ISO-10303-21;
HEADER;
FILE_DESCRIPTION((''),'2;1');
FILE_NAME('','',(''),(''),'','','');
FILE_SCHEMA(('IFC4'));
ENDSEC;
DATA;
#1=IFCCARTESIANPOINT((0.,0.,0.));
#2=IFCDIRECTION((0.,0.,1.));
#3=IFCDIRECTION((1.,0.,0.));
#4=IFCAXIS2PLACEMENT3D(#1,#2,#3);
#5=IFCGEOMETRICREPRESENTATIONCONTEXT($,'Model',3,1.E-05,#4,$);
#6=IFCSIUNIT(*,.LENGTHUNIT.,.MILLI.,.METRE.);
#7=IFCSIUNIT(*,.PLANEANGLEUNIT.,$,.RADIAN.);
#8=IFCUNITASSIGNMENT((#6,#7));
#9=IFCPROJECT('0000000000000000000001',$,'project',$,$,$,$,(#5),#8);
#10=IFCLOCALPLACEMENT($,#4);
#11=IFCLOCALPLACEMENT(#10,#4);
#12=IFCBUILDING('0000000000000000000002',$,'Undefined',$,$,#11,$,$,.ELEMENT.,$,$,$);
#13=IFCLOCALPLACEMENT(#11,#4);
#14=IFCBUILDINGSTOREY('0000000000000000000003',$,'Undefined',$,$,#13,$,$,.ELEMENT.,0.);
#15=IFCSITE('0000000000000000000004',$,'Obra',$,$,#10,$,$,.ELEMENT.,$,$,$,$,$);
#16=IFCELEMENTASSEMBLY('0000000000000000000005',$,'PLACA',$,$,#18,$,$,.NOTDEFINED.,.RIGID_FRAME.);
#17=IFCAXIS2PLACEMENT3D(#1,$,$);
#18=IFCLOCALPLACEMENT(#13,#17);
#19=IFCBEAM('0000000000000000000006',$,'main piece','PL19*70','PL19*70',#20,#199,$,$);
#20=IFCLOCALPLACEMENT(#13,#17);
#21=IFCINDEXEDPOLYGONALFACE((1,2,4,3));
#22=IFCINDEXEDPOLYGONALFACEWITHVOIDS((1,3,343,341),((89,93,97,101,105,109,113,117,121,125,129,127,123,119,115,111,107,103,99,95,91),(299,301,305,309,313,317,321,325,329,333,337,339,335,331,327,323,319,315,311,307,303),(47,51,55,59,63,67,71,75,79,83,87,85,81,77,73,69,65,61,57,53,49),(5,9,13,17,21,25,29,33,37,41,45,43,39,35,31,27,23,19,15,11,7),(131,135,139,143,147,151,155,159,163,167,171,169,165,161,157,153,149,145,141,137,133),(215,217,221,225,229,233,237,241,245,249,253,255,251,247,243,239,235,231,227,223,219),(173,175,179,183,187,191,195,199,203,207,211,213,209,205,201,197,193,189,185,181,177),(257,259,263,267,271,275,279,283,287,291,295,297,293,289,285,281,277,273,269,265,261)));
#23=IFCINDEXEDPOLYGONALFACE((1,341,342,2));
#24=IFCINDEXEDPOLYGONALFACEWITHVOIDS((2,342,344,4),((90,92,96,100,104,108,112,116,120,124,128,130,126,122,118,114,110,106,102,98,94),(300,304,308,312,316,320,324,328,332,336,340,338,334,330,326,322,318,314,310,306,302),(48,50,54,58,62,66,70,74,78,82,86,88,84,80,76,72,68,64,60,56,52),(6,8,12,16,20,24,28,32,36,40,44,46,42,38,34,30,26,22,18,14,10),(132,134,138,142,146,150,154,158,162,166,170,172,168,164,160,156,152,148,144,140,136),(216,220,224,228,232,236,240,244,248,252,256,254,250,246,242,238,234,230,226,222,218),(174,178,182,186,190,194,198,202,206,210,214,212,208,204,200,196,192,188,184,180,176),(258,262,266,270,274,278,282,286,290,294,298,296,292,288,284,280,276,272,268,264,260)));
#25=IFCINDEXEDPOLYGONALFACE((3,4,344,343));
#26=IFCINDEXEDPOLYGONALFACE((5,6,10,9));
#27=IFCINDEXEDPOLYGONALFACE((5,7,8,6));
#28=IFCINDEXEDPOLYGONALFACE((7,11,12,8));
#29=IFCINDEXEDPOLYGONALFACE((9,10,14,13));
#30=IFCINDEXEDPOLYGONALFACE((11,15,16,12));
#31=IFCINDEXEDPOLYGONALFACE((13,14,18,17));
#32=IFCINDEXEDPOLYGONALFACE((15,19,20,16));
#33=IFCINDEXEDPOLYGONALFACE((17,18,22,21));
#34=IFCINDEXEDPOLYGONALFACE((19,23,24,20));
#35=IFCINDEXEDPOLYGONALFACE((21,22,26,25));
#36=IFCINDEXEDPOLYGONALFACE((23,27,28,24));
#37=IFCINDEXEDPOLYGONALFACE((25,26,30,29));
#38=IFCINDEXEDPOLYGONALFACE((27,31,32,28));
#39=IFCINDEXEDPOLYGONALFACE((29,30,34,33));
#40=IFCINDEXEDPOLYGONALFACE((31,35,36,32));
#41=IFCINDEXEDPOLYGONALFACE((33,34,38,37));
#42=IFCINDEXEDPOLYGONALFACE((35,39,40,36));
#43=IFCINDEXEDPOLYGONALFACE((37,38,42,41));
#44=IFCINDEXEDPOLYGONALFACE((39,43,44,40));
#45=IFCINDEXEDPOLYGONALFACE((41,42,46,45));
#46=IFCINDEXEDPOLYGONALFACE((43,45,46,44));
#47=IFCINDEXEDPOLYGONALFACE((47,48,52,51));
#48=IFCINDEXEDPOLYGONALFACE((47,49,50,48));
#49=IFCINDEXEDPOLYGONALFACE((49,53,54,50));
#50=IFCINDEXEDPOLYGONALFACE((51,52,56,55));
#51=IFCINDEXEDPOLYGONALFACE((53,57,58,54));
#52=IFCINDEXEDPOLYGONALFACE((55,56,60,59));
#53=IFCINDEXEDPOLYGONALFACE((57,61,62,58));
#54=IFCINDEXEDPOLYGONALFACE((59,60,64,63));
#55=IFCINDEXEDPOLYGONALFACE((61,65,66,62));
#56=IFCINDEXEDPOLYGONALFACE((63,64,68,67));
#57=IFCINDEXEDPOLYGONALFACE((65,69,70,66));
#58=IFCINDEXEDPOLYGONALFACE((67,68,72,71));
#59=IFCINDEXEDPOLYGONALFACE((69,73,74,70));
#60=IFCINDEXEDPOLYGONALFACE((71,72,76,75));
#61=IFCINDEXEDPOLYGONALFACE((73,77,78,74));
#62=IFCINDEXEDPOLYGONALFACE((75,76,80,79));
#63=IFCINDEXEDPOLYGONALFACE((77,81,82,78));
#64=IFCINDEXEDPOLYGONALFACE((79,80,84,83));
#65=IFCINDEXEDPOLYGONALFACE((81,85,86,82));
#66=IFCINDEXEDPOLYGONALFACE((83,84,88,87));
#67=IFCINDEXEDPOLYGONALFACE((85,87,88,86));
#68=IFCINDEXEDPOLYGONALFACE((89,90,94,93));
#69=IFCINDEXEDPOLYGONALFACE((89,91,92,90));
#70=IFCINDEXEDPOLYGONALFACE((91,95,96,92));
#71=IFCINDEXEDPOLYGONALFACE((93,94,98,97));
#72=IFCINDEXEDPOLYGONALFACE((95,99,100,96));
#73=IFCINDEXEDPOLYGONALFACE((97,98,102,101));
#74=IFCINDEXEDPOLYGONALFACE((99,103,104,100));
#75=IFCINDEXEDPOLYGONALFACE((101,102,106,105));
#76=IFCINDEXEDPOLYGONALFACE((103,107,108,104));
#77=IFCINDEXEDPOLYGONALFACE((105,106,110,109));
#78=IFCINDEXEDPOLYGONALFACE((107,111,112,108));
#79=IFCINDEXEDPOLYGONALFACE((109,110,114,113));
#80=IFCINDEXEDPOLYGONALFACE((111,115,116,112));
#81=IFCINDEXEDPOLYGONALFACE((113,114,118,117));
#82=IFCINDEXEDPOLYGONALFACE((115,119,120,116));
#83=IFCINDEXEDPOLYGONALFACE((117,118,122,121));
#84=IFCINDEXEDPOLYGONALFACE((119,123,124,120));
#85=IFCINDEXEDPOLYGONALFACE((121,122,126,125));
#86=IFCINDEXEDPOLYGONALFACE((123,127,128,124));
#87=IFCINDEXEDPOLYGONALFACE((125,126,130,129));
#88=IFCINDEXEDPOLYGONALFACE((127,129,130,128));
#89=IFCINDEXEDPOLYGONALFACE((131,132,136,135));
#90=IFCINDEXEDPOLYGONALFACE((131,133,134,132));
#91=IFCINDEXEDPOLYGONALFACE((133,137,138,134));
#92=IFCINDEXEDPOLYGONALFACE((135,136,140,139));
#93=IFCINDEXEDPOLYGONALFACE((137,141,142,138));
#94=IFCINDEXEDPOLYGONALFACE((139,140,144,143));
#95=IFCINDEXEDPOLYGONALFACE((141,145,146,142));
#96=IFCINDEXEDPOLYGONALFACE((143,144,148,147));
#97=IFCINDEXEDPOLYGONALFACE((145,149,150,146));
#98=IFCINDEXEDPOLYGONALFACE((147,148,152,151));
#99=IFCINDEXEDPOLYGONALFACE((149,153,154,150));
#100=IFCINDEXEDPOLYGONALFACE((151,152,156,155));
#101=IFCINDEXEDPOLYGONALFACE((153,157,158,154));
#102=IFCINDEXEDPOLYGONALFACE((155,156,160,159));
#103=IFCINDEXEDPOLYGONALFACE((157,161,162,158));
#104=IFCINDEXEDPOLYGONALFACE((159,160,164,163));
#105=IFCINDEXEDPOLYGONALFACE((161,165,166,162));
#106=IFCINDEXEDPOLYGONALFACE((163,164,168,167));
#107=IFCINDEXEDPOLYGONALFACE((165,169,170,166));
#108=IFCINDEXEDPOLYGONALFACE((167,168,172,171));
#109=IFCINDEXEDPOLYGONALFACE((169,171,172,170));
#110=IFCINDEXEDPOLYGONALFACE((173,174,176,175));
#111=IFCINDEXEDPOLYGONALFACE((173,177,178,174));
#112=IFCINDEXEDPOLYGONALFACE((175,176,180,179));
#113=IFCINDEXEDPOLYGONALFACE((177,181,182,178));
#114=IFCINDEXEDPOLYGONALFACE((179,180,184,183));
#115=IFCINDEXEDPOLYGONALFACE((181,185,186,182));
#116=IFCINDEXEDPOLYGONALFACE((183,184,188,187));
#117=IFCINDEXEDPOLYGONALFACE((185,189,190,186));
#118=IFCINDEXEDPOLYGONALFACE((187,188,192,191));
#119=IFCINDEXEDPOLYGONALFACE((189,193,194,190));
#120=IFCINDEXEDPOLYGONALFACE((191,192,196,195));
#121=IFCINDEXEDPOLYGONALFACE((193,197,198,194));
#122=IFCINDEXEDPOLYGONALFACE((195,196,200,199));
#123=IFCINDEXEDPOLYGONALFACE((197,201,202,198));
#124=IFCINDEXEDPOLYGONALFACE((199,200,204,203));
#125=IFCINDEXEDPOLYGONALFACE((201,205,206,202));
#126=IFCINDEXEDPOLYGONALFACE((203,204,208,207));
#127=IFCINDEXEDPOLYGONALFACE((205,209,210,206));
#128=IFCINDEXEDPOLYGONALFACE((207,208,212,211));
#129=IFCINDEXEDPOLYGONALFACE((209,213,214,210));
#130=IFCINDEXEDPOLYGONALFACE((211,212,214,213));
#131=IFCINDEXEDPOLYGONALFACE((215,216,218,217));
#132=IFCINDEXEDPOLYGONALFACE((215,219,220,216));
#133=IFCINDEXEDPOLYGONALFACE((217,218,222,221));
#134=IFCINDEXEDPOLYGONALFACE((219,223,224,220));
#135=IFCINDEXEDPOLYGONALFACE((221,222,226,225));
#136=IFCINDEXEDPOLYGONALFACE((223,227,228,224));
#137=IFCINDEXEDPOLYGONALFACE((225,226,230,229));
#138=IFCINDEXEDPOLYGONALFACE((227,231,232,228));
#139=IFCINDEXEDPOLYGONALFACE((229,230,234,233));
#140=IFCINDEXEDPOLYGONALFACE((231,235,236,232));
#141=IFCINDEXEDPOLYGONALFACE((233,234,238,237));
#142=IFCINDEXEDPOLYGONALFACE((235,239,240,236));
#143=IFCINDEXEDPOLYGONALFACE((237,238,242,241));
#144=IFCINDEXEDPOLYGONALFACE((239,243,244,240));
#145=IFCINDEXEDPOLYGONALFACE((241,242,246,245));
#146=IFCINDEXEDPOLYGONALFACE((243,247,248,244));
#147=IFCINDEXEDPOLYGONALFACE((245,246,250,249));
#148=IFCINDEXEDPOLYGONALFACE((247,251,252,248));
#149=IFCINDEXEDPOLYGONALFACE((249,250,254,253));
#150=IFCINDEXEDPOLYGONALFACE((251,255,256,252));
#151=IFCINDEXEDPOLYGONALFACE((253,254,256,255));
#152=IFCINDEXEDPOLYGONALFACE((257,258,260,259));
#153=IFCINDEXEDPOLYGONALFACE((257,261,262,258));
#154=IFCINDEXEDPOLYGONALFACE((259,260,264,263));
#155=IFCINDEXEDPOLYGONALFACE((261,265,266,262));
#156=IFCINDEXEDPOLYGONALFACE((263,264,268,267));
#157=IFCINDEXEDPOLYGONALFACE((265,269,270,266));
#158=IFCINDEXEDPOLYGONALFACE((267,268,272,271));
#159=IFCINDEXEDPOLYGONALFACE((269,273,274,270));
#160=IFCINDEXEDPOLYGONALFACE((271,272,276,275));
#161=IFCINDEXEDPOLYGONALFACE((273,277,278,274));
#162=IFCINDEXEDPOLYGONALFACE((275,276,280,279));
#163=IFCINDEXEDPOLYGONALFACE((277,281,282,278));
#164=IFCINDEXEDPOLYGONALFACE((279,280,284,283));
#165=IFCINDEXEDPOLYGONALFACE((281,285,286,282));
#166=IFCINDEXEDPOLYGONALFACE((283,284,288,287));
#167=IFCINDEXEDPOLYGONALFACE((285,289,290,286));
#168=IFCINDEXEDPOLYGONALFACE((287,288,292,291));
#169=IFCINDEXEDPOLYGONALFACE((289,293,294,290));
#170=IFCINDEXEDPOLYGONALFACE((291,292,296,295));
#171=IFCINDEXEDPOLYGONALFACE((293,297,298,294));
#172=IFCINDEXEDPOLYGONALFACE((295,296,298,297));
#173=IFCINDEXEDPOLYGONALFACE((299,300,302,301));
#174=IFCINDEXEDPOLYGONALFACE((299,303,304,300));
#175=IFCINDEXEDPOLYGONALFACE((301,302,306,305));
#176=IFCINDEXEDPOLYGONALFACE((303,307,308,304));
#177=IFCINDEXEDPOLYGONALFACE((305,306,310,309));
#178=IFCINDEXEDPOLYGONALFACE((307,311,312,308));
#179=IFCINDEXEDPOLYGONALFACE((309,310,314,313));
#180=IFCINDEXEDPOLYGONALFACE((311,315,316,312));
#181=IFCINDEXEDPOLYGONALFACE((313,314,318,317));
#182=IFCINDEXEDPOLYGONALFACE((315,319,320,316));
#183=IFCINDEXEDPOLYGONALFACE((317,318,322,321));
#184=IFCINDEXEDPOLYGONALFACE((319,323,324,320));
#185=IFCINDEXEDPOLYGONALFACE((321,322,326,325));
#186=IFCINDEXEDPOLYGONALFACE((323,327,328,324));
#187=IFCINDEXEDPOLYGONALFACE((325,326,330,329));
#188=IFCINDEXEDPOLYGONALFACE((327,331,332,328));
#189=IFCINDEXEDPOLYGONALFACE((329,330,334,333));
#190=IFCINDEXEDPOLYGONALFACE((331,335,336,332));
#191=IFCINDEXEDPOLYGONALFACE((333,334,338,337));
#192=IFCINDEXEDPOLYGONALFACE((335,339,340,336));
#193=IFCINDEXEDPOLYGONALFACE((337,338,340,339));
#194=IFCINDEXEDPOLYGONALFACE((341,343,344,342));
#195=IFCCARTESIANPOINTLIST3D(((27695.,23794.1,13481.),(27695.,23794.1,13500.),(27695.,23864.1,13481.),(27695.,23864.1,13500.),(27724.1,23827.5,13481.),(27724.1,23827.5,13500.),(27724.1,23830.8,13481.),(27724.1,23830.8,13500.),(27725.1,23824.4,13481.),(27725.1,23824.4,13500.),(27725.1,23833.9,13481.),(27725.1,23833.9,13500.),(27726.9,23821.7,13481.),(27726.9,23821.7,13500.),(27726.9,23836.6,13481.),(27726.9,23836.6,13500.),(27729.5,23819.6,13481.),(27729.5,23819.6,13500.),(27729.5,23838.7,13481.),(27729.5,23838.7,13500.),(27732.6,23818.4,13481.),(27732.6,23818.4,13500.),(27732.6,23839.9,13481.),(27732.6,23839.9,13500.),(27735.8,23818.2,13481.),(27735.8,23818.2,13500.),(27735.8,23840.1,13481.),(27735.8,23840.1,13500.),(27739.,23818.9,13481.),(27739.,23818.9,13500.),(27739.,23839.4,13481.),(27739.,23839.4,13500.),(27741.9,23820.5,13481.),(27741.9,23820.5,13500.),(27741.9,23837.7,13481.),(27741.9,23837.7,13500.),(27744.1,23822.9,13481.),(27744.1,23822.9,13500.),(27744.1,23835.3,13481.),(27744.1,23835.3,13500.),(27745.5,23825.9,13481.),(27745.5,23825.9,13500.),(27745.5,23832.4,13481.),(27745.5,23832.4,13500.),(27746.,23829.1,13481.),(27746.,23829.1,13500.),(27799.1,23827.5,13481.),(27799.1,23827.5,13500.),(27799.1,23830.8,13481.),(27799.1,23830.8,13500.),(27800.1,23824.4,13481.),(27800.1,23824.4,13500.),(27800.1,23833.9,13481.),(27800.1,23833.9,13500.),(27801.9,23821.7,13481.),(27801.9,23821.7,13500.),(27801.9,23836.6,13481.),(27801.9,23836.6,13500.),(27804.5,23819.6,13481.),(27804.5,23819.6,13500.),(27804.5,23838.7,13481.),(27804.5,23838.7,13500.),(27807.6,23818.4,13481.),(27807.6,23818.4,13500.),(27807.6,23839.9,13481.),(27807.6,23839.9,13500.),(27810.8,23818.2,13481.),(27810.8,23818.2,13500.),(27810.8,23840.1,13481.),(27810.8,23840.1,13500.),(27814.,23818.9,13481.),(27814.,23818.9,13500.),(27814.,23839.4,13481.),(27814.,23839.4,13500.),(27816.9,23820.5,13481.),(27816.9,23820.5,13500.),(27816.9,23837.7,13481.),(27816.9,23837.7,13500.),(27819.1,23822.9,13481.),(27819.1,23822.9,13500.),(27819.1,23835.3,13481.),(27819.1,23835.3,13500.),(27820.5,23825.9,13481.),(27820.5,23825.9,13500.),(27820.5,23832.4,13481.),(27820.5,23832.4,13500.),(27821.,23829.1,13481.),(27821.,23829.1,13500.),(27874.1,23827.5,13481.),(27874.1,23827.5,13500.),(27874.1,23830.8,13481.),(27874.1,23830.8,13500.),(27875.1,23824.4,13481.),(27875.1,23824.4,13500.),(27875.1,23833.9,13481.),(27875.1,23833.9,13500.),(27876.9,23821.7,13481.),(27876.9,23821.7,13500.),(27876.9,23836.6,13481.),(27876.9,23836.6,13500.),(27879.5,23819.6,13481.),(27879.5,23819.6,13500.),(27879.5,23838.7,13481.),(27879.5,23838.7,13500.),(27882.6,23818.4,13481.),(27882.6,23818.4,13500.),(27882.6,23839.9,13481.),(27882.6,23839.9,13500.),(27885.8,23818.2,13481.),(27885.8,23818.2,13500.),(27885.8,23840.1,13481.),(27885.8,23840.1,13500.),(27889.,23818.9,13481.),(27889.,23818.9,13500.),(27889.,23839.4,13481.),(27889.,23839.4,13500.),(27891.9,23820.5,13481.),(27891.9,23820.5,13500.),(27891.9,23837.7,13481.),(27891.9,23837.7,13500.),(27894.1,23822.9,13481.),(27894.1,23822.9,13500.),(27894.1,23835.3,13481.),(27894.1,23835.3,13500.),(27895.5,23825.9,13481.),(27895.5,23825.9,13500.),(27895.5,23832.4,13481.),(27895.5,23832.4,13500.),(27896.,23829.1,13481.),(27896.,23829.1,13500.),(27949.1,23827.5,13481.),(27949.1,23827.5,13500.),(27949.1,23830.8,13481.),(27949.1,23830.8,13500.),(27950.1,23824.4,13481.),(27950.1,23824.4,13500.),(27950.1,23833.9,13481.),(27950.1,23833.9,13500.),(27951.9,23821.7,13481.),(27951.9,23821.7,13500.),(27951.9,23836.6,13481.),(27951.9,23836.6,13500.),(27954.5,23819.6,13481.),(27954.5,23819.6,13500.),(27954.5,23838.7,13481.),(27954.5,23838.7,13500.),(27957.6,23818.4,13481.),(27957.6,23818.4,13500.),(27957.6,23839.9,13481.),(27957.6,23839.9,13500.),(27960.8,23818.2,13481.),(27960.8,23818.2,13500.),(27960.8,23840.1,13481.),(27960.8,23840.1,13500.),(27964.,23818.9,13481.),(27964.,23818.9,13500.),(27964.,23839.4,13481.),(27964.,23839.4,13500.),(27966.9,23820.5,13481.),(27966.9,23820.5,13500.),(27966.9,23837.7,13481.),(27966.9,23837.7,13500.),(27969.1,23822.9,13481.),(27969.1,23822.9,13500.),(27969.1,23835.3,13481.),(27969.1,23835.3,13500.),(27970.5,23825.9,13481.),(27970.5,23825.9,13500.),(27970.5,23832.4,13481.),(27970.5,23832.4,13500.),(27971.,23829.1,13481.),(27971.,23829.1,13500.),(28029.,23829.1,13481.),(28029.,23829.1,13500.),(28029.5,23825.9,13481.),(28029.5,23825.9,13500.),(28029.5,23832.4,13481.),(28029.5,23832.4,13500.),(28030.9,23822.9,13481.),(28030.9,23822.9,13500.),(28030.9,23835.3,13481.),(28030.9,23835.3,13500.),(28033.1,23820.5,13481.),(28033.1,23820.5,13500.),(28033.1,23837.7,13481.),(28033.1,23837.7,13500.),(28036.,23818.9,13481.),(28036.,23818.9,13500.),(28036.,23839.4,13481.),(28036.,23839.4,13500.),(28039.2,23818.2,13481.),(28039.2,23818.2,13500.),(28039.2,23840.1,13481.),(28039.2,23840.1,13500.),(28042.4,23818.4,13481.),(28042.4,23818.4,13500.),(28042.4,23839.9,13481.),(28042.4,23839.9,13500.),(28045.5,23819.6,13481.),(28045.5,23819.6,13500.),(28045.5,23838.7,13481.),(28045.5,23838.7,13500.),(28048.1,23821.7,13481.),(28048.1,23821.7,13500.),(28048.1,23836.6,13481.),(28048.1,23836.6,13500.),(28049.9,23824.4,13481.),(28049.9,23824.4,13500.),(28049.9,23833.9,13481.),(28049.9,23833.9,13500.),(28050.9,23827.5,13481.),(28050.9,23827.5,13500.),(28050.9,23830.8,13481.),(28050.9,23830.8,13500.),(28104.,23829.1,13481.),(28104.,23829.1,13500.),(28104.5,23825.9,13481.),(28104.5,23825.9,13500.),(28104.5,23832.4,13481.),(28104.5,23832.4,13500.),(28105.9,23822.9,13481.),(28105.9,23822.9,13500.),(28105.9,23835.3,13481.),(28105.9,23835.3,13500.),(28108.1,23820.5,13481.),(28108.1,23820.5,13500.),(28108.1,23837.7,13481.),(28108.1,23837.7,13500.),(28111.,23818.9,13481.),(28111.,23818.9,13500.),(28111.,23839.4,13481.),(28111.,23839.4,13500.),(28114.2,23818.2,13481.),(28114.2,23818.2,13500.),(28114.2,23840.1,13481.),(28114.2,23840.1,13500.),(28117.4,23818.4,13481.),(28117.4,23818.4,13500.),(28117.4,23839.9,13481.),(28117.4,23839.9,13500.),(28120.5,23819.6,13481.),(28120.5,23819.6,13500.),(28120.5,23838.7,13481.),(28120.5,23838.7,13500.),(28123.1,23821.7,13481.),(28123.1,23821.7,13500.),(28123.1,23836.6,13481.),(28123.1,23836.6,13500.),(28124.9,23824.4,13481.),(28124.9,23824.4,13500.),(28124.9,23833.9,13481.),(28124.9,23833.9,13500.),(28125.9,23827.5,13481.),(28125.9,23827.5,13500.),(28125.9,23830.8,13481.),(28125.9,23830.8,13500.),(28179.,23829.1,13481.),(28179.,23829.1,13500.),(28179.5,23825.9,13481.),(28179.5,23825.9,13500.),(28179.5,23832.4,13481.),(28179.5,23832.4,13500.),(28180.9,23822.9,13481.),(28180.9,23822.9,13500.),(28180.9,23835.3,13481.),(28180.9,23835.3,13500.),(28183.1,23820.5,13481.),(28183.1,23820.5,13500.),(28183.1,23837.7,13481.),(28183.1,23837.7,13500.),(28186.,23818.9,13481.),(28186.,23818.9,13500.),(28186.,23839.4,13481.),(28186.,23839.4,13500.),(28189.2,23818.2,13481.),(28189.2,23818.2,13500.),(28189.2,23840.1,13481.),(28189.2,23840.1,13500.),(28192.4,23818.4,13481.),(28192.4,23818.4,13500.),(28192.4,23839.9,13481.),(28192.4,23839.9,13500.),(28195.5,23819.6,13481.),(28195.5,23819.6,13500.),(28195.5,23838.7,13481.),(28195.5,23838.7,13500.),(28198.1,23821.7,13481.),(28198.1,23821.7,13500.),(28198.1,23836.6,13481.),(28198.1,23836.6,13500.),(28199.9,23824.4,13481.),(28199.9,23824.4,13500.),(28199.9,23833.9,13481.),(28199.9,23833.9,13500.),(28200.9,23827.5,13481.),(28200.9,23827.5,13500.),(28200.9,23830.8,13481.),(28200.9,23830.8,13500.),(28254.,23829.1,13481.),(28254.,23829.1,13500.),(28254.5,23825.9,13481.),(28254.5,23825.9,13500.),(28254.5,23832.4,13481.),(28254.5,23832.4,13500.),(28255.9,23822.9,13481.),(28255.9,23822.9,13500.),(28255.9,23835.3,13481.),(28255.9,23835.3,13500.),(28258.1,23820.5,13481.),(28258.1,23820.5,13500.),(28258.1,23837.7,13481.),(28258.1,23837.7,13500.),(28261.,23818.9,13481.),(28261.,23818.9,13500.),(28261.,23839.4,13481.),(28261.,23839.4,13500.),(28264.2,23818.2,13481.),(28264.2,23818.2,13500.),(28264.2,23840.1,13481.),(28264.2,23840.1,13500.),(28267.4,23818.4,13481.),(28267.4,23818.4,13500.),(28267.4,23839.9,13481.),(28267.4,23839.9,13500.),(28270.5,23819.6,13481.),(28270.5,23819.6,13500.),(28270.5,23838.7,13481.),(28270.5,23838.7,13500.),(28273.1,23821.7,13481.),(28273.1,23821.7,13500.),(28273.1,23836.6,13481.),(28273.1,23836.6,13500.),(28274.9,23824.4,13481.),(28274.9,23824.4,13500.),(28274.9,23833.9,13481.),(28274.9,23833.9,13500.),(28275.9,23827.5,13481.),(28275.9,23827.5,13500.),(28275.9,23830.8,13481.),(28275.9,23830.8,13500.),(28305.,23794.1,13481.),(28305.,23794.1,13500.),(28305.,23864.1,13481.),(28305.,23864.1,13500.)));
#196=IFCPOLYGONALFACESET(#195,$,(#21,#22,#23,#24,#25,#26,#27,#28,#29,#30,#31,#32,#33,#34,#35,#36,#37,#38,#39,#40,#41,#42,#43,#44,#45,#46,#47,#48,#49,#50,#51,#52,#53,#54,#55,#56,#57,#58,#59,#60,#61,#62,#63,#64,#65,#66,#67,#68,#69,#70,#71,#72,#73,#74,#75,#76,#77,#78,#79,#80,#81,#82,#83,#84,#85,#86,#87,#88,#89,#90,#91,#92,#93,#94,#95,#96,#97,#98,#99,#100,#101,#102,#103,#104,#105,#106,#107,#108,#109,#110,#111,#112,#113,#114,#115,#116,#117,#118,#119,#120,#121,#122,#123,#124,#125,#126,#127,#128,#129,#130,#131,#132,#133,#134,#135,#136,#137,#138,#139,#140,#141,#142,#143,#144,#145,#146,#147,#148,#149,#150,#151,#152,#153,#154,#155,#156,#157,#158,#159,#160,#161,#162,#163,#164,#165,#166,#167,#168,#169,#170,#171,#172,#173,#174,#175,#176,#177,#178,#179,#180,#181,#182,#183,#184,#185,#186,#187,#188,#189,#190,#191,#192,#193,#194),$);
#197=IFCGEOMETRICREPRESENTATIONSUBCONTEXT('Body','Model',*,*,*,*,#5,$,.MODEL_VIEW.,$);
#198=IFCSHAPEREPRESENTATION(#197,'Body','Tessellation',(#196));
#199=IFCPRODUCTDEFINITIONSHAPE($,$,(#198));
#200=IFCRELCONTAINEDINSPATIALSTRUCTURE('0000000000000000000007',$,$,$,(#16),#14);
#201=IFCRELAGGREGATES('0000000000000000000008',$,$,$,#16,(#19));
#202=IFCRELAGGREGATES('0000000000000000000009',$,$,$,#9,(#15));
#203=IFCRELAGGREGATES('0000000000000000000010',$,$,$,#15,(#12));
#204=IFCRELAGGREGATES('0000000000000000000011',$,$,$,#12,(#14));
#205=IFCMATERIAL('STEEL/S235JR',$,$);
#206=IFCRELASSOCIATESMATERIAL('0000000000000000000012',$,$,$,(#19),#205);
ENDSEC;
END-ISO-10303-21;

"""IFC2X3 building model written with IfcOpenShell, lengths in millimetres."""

from ifc_helpers import new_model, si_unit, frame, origin_with_axes, origin_2d_with_axis, place, context, subcontext, project, spatial, rectangle, circle, extrude, source, transform, mapped, material, element, aggregate, save


model = new_model("IFC2X3")

# Units and contexts
model_context = context("Model", 3, precision=1e-05, world=origin_with_axes())
body_context = subcontext(model_context, "Body", "Model", "MODEL_VIEW")
ifc_project = project(units=[si_unit("LENGTHUNIT", "METRE", prefix="MILLI"), si_unit("PLANEANGLEUNIT", "RADIAN")], contexts=[model_context])

# Site, building, storey
site_placement = place(None, origin_with_axes())
site = spatial("IfcSite", under=ifc_project, at=site_placement, Name="Obra", CompositionType="ELEMENT")
building_placement = place(site_placement, origin_with_axes())
building = spatial("IfcBuilding", under=site, at=building_placement, Name="Undefined", CompositionType="ELEMENT")
storey_placement = place(building_placement, origin_with_axes())
storey = spatial("IfcBuildingStorey", under=building, at=storey_placement, Name="Undefined", CompositionType="ELEMENT", Elevation=0.0)

# Shared definitions
ifc_material_1 = material(Name="STEEL/S235JR")

# Element assembly, beam, openings
shared_shape_1 = source(origin_with_axes(), body_context, "Body", "SweptSolid", [
    extrude(circle(Radius=11.0, at=origin_2d_with_axis()), frame((0.0, -19.1, 0.0), z_axis=(0.0, 1.0, 0.0), x_axis=(1.0, 0.0, 0.0)), (0.0, 0.0, 1.0), 19.2),
])
assembly_1_placement = place(storey_placement, origin_with_axes())
assembly_1 = element("IfcElementAssembly", 1, at=assembly_1_placement, inside=storey, Name="PLACA", AssemblyPlace="NOTDEFINED", PredefinedType="RIGID_FRAME")
beam_1_placement = place(assembly_1_placement, frame((28305.0, 23829.1, 13490.5), z_axis=(0.0, -1.0, 0.0), x_axis=(-1.0, 0.0, 0.0)))
beam_1 = element("IfcBeam", 2, at=beam_1_placement, material=ifc_material_1, Name="main piece", Description="PL19*70", ObjectType="PL19*70", context=body_context, shape_type="SweptSolid", body=[
    extrude(rectangle(XDim=19.0, YDim=70.0, at=origin_2d_with_axis()), frame((610.0, 0.0, 0.0), z_axis=(-1.0, 0.0, 0.0), x_axis=(0.0, -1.0, 0.0)), (0.0, 0.0, 1.0), 610.0),
])
opening_1_placement = place(assembly_1_placement, frame((28265.0, 23829.1, 13481.0), z_axis=(0.0, -1.0, 0.0), x_axis=(-1.0, 0.0, 0.0)))
element("IfcOpeningElement", 3, at=opening_1_placement, cuts=beam_1, ObjectType="Opening", context=body_context, shape_type="MappedRepresentation", body=[
    mapped(shared_shape_1, transform((0.0, 0.0, 0.0))),
    mapped(shared_shape_1, transform((75.0, 0.0, 0.0))),
    mapped(shared_shape_1, transform((150.0, 0.0, 0.0))),
    mapped(shared_shape_1, transform((225.0, 0.0, 0.0))),
])
opening_2_placement = place(assembly_1_placement, frame((27735.0, 23829.1, 13481.0), z_axis=(0.0, 1.0, 0.0), x_axis=(1.0, 0.0, 0.0)))
element("IfcOpeningElement", 4, at=opening_2_placement, cuts=beam_1, ObjectType="Opening", context=body_context, shape_type="MappedRepresentation", body=[
    mapped(shared_shape_1, transform((0.0, 0.0, 0.0))),
    mapped(shared_shape_1, transform((75.0, 0.0, 0.0))),
    mapped(shared_shape_1, transform((150.0, 0.0, 0.0))),
    mapped(shared_shape_1, transform((225.0, 0.0, 0.0))),
])
aggregate(assembly_1, [beam_1])

save(model, "model.ifc")
